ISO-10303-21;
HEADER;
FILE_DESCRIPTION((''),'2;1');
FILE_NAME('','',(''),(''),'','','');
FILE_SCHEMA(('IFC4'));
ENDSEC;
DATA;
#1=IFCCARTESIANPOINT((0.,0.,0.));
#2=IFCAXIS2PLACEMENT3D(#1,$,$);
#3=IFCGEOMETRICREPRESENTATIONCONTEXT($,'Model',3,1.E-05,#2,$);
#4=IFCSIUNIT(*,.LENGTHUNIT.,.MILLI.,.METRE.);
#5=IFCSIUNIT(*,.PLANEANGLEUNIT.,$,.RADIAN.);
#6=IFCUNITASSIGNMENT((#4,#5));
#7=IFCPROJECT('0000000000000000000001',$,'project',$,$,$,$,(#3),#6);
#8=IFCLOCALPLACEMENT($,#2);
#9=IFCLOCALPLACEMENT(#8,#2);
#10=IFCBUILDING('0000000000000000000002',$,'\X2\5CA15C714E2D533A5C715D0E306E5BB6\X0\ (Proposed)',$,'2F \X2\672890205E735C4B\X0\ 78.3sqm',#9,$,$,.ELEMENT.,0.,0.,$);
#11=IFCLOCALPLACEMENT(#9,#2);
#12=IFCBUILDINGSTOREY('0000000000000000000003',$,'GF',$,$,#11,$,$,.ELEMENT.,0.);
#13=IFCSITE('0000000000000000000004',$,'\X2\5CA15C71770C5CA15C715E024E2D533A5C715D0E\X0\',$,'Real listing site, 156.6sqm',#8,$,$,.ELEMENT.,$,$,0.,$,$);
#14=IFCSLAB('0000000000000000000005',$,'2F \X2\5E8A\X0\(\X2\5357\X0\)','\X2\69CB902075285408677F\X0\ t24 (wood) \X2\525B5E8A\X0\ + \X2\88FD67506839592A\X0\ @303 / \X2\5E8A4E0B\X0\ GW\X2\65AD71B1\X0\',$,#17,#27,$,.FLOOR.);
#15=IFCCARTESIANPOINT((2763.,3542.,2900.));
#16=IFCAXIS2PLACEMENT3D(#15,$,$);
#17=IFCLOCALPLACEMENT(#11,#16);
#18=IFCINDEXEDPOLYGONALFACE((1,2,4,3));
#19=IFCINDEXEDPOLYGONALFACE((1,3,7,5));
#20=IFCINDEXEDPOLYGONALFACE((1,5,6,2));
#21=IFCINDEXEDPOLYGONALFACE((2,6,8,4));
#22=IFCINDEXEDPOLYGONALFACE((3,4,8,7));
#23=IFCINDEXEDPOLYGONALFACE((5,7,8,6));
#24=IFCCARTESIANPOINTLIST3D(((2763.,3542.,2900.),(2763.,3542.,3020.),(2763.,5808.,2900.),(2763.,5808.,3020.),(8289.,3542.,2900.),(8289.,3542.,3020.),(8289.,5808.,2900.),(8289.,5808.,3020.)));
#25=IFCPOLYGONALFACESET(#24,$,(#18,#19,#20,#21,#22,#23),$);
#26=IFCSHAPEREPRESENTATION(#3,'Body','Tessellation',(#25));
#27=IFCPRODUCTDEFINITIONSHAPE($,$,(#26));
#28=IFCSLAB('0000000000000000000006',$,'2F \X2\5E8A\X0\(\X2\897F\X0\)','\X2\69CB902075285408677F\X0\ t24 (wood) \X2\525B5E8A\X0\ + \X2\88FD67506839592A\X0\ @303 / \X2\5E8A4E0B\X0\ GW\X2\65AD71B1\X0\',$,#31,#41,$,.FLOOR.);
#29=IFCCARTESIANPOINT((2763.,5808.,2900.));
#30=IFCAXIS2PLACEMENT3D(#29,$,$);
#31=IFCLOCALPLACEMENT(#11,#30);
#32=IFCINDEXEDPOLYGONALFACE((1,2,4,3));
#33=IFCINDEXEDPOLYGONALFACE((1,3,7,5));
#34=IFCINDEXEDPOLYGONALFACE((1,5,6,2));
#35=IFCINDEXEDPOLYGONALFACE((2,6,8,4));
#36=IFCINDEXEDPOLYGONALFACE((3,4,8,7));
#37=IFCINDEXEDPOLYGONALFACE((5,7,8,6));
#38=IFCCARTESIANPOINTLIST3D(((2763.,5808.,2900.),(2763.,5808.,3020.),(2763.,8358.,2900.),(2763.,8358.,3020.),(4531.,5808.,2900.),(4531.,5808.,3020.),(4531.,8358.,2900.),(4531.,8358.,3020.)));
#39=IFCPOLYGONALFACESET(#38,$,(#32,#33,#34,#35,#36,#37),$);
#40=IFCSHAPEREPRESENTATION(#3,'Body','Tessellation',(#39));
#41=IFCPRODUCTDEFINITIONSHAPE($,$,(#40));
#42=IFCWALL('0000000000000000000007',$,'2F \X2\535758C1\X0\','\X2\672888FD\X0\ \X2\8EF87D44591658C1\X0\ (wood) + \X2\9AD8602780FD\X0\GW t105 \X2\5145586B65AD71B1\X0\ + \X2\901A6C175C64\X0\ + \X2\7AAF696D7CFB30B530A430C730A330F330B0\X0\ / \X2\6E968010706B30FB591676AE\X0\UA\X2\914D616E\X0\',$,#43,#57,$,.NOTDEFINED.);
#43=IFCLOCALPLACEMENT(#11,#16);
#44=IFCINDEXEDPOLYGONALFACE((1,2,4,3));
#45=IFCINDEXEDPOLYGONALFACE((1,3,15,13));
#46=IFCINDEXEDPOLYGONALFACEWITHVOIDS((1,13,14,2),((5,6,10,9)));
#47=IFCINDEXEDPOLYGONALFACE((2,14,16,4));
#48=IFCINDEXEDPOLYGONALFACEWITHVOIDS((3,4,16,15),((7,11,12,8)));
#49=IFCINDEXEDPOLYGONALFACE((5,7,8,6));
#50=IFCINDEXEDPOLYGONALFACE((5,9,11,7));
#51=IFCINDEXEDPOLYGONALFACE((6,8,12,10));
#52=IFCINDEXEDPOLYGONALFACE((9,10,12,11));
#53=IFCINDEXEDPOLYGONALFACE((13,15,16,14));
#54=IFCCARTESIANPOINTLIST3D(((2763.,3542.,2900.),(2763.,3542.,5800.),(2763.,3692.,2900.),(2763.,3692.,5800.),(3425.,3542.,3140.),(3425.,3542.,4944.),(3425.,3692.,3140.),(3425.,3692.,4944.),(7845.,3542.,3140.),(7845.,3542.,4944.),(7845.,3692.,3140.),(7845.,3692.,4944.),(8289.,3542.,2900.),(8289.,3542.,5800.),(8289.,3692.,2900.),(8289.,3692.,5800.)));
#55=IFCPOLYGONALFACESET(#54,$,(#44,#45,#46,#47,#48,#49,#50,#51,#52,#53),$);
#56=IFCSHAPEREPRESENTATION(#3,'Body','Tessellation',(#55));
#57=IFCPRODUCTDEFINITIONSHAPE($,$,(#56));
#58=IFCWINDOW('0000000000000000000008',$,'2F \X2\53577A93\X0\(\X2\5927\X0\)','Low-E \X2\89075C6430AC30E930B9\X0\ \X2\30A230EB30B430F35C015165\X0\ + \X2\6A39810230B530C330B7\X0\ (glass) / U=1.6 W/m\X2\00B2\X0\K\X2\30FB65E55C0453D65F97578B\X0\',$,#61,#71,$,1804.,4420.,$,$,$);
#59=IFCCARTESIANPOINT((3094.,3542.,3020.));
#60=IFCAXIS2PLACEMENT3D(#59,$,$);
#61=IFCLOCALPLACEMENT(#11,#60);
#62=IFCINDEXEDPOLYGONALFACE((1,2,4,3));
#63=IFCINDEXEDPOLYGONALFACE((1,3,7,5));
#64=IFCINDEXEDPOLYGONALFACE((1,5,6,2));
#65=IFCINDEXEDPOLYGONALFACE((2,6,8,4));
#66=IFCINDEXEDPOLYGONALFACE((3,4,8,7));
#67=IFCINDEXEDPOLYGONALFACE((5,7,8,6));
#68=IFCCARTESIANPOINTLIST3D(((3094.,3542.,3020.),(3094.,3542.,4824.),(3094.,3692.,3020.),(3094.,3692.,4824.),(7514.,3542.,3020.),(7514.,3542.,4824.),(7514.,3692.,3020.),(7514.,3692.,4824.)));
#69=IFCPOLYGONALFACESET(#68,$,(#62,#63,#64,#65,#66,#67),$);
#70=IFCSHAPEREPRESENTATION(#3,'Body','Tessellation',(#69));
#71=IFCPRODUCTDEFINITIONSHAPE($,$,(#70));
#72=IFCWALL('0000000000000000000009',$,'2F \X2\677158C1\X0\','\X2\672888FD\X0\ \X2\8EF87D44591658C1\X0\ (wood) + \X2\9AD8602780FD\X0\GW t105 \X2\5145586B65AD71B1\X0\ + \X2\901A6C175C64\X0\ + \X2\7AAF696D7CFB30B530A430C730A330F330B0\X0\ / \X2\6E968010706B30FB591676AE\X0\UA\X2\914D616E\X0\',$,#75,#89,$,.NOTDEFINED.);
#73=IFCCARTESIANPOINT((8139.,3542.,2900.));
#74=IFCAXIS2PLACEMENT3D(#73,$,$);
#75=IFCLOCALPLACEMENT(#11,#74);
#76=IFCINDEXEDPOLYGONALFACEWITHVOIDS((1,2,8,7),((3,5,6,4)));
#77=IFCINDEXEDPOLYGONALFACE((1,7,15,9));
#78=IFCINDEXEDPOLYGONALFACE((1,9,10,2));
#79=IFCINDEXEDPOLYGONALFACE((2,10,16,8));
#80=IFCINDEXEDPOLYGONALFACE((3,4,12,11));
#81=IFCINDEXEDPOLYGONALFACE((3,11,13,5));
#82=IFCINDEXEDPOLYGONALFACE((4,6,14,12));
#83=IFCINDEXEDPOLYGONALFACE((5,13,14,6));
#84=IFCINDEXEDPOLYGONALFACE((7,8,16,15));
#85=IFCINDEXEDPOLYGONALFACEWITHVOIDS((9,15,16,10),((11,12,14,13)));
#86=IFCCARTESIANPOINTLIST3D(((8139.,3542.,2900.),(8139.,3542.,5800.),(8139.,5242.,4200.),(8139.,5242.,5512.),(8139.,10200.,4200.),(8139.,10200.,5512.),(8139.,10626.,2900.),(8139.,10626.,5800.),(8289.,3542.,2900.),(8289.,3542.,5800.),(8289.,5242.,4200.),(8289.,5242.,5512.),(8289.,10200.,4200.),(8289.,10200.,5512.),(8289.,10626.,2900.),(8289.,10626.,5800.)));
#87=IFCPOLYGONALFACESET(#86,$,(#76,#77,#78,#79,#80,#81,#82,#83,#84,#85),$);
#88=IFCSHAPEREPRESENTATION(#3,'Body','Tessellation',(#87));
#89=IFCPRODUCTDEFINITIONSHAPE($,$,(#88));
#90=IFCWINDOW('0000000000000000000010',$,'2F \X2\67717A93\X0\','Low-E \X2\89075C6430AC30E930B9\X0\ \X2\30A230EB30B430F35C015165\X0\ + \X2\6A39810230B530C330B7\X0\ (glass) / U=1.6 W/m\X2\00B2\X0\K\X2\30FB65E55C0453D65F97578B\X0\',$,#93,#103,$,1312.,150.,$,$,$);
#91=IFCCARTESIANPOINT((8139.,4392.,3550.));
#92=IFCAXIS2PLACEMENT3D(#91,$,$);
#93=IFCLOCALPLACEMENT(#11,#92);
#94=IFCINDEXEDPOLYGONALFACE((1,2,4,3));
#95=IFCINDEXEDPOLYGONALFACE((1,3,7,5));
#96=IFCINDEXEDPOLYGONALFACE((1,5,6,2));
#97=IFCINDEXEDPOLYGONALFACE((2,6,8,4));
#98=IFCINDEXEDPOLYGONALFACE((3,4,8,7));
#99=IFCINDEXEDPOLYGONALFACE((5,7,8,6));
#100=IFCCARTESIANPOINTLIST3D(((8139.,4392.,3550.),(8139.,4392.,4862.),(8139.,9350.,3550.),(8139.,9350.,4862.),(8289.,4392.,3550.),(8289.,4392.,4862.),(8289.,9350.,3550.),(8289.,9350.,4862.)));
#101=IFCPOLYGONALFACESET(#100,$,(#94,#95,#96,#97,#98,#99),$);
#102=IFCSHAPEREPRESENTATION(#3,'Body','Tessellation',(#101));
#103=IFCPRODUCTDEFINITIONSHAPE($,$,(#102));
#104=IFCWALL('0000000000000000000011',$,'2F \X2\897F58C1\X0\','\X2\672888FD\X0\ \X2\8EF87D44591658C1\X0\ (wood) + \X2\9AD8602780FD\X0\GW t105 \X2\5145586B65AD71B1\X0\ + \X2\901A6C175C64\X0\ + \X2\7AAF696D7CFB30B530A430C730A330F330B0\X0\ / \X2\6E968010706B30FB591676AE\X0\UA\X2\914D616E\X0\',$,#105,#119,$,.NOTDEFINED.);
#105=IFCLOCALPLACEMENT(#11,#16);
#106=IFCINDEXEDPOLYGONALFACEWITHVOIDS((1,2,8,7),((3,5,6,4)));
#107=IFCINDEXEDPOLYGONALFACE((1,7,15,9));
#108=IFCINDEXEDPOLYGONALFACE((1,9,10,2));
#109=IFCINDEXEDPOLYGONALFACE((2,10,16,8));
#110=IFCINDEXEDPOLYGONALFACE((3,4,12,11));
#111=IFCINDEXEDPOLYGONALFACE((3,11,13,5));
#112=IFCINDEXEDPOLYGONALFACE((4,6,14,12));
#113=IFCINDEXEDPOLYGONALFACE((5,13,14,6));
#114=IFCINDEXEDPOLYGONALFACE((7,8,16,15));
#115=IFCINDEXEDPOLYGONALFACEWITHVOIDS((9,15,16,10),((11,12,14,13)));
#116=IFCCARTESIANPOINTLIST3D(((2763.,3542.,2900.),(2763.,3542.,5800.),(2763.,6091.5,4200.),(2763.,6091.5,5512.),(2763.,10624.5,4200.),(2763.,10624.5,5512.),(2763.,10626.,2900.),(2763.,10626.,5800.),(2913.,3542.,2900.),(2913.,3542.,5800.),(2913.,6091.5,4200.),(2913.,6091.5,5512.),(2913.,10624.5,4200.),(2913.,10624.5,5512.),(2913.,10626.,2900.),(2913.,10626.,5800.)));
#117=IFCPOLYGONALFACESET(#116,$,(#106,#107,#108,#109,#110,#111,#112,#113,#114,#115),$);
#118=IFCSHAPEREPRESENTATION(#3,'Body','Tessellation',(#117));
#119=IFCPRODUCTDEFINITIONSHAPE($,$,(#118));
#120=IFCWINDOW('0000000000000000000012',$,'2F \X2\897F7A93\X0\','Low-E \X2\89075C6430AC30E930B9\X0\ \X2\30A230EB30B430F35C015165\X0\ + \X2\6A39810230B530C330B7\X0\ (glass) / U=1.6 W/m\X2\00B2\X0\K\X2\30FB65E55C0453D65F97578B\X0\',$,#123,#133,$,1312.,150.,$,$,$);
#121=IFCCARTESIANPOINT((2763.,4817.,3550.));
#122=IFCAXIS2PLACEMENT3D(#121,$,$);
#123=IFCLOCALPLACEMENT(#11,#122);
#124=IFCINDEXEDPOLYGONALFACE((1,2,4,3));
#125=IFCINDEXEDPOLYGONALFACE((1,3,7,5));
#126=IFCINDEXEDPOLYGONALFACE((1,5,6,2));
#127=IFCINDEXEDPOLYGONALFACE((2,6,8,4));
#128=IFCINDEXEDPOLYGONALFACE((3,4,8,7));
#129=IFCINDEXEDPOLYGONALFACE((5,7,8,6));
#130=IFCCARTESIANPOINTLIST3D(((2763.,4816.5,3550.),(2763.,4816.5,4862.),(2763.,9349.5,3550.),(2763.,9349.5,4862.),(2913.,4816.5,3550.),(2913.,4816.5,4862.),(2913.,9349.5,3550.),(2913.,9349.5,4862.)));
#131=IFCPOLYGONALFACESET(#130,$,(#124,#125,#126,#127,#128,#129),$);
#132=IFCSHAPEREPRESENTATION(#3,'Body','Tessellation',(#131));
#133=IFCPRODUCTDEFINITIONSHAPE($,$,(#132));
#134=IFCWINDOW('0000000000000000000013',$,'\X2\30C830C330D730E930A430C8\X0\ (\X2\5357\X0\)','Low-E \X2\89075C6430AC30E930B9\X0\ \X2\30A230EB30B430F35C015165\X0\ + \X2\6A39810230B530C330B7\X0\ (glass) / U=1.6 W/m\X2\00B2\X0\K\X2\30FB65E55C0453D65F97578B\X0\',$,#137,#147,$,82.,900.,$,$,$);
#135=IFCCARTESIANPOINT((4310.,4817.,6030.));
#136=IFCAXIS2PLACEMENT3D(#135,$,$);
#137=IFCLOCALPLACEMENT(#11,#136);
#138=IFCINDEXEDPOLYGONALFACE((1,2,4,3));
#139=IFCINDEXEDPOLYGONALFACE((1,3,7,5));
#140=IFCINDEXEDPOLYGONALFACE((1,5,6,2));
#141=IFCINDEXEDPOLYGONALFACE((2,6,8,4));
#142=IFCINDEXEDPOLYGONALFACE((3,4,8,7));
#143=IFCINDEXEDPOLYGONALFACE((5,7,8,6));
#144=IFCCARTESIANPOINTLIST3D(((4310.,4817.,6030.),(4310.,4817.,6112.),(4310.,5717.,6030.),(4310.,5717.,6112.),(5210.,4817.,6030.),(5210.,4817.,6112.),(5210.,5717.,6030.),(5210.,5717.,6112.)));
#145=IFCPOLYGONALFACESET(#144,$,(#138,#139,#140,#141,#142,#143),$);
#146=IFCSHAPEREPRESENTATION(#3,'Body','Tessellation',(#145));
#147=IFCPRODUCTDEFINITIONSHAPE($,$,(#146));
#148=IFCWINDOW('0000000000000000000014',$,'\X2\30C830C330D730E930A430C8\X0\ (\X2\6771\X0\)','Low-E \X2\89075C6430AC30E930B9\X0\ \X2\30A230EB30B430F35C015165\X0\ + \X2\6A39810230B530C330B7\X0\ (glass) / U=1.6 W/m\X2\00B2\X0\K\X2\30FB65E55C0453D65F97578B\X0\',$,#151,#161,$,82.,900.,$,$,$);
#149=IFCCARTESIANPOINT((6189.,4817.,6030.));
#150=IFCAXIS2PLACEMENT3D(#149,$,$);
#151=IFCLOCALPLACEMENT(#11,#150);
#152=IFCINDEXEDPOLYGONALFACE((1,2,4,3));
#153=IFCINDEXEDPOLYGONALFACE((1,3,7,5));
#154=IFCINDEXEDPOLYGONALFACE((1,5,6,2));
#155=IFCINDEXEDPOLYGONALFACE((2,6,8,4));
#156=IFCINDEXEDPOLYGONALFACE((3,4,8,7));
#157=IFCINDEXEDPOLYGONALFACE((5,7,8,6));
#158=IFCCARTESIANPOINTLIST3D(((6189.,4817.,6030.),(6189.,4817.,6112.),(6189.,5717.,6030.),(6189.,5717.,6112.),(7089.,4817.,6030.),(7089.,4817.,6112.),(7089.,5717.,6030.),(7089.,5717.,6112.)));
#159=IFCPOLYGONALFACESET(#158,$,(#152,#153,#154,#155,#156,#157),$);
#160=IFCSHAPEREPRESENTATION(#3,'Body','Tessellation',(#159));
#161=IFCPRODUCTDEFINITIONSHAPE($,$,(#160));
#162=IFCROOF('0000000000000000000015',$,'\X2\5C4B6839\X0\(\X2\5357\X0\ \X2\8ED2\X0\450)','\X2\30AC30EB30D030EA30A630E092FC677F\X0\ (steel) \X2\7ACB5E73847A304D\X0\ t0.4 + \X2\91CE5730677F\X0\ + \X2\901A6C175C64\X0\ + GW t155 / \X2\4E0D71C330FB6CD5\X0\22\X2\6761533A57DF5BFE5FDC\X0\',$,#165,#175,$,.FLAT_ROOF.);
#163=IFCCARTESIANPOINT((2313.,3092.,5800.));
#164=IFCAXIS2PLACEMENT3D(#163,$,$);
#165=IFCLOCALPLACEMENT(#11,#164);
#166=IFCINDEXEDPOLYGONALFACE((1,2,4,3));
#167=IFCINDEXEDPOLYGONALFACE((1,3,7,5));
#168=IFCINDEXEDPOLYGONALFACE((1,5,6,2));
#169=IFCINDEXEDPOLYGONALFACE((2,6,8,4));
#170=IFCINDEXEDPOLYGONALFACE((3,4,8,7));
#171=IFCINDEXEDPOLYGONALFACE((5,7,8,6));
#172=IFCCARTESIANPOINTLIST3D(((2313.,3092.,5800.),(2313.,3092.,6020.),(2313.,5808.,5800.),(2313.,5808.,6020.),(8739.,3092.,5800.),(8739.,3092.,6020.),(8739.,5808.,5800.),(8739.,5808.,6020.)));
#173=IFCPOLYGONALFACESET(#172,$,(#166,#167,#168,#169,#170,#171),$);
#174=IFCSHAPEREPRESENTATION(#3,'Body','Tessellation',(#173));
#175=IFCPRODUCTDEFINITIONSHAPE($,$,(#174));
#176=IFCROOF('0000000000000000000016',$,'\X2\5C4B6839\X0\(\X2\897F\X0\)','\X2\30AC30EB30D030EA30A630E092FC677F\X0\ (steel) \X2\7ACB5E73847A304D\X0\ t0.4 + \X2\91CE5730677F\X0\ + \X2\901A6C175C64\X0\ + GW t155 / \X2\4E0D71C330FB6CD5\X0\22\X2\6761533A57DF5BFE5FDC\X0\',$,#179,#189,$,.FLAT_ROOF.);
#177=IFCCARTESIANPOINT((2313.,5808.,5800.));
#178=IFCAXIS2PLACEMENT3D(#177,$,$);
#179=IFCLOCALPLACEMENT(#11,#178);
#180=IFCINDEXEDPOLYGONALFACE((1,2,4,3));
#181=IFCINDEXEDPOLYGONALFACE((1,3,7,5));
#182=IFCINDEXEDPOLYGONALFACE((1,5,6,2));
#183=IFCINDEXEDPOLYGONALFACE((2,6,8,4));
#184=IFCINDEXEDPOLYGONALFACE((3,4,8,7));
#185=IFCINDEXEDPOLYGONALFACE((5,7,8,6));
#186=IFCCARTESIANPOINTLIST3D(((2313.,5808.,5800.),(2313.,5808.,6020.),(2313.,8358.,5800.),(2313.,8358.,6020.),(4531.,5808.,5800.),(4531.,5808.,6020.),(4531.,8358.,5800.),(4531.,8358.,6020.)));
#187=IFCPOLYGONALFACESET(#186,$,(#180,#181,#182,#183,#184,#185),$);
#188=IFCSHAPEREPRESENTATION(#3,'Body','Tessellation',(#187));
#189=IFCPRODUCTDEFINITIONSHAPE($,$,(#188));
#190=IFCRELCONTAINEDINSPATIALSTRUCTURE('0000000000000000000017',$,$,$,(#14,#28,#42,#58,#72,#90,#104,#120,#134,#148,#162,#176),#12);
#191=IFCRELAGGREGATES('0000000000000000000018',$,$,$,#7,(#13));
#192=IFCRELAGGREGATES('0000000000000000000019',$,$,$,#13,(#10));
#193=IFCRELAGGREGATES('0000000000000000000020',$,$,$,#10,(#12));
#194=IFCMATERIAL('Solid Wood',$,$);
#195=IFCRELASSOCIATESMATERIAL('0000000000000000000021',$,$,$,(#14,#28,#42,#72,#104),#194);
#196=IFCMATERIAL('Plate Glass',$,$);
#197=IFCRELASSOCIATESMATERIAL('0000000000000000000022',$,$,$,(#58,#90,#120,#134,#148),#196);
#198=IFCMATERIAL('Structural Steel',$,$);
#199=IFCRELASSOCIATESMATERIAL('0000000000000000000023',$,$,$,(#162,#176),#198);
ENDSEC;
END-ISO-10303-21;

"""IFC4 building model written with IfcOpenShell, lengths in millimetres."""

from ifc_helpers import new_model, si_unit, frame, frame_2d, origin, place, context, project, spatial, rectangle, extrude, material, element, fill, save


model = new_model("IFC4")

# Units and contexts
model_context = context("Model", 3, precision=1e-05, world=origin())
ifc_project = project(units=[si_unit("LENGTHUNIT", "METRE", prefix="MILLI"), si_unit("PLANEANGLEUNIT", "RADIAN")], contexts=[model_context])

# Site, building, storey
site_placement = place(None, origin())
site = spatial("IfcSite", under=ifc_project, at=site_placement, Name="岡山県岡山市中区山崎", ObjectType="Real listing site, 156.6sqm", CompositionType="ELEMENT", RefElevation=0.0)
building_placement = place(site_placement, origin())
building = spatial("IfcBuilding", under=site, at=building_placement, Name="岡山中区山崎の家 (Proposed)", ObjectType="2F 木造平屋 78.3sqm", CompositionType="ELEMENT", ElevationOfRefHeight=0.0, ElevationOfTerrain=0.0)
storey_placement = place(building_placement, origin())
storey = spatial("IfcBuildingStorey", under=building, at=storey_placement, Name="GF", CompositionType="ELEMENT", Elevation=0.0)

# Slabs
ifc_material_1 = material(Name="Solid Wood")
slab_1_placement = place(storey_placement, frame((2763.0, 3542.0, 2900.0)))
element("IfcSlab", 1, at=slab_1_placement, inside=storey, material=ifc_material_1, Name="2F 床(南)", Description="構造用合板 t24 (wood) 剛床 + 製材根太 @303 / 床下 GW断熱", PredefinedType="FLOOR", context=model_context, shape_type="SweptSolid", body=[
    extrude(rectangle(XDim=5526.0, YDim=2266.0, at=frame_2d((2763.0, 1133.0))), frame((2763.0, 3542.0, 2900.0)), (0.0, 0.0, 1.0), 120.0),
])
slab_2_placement = place(storey_placement, frame((2763.0, 5808.0, 2900.0)))
element("IfcSlab", 2, at=slab_2_placement, inside=storey, material=ifc_material_1, Name="2F 床(西)", Description="構造用合板 t24 (wood) 剛床 + 製材根太 @303 / 床下 GW断熱", PredefinedType="FLOOR", context=model_context, shape_type="SweptSolid", body=[
    extrude(rectangle(XDim=1768.0, YDim=2550.0, at=frame_2d((884.0, 1275.0))), frame((2763.0, 5808.0, 2900.0)), (0.0, 0.0, 1.0), 120.0),
])

# Walls, openings, windows
wall_1_placement = place(storey_placement, frame((2763.0, 3542.0, 2900.0)))
wall_1 = element("IfcWall", 3, at=wall_1_placement, inside=storey, material=ifc_material_1, Name="2F 南壁", Description="木製 軸組外壁 (wood) + 高性能GW t105 充填断熱 + 通気層 + 窯業系サイディング / 準耐火・外皮UA配慮", PredefinedType="NOTDEFINED", context=model_context, shape_type="SweptSolid", body=[
    extrude(rectangle(XDim=5526.0, YDim=150.0, at=frame_2d((2763.0, 75.0))), frame((2763.0, 3542.0, 2900.0)), (0.0, 0.0, 1.0), 2900.0),
])
opening_1_placement = place(storey_placement, frame((3094.0, 3542.0, 3020.0)))
opening_1 = element("IfcOpeningElement", 4, at=opening_1_placement, cuts=wall_1, PredefinedType="NOTDEFINED", context=model_context, shape_type="SweptSolid", body=[
    extrude(rectangle(XDim=4420.0, YDim=150.0, at=frame_2d((2210.0, 75.0))), frame((3094.0, 3542.0, 3020.0)), (0.0, 0.0, 1.0), 1804.0),
])
ifc_material_2 = material(Name="Plate Glass")
window_1_placement = place(storey_placement, frame((3094.0, 3542.0, 3020.0)))
window_1 = element("IfcWindow", 5, at=window_1_placement, inside=storey, material=ifc_material_2, Name="2F 南窓(大)", Description="Low-E 複層ガラス アルゴン封入 + 樹脂サッシ (glass) / U=1.6 W/m²K・日射取得型", OverallHeight=1804.0, OverallWidth=4420.0, context=model_context, shape_type="SweptSolid", body=[
    extrude(rectangle(XDim=4420.0, YDim=150.0, at=frame_2d((2210.0, 75.0))), frame((3094.0, 3542.0, 3020.0)), (0.0, 0.0, 1.0), 1804.0),
])
fill(opening_1, window_1)
wall_2_placement = place(storey_placement, frame((8139.0, 3542.0, 2900.0)))
wall_2 = element("IfcWall", 6, at=wall_2_placement, inside=storey, material=ifc_material_1, Name="2F 東壁", Description="木製 軸組外壁 (wood) + 高性能GW t105 充填断熱 + 通気層 + 窯業系サイディング / 準耐火・外皮UA配慮", PredefinedType="NOTDEFINED", context=model_context, shape_type="SweptSolid", body=[
    extrude(rectangle(XDim=150.0, YDim=7084.0, at=frame_2d((75.0, 3542.0))), frame((8139.0, 3542.0, 2900.0)), (0.0, 0.0, 1.0), 2900.0),
])
opening_2_placement = place(storey_placement, frame((8139.0, 4392.0, 3550.0)))
opening_2 = element("IfcOpeningElement", 7, at=opening_2_placement, cuts=wall_2, PredefinedType="NOTDEFINED", context=model_context, shape_type="SweptSolid", body=[
    extrude(rectangle(XDim=150.0, YDim=4958.0, at=frame_2d((75.0, 2479.0))), frame((8139.0, 4392.0, 3550.0)), (0.0, 0.0, 1.0), 1312.0),
])
window_2_placement = place(storey_placement, frame((8139.0, 4392.0, 3550.0)))
window_2 = element("IfcWindow", 8, at=window_2_placement, inside=storey, material=ifc_material_2, Name="2F 東窓", Description="Low-E 複層ガラス アルゴン封入 + 樹脂サッシ (glass) / U=1.6 W/m²K・日射取得型", OverallHeight=1312.0, OverallWidth=150.0, context=model_context, shape_type="SweptSolid", body=[
    extrude(rectangle(XDim=150.0, YDim=4958.0, at=frame_2d((75.0, 2479.0))), frame((8139.0, 4392.0, 3550.0)), (0.0, 0.0, 1.0), 1312.0),
])
fill(opening_2, window_2)
wall_3_placement = place(storey_placement, frame((2763.0, 3542.0, 2900.0)))
wall_3 = element("IfcWall", 9, at=wall_3_placement, inside=storey, material=ifc_material_1, Name="2F 西壁", Description="木製 軸組外壁 (wood) + 高性能GW t105 充填断熱 + 通気層 + 窯業系サイディング / 準耐火・外皮UA配慮", PredefinedType="NOTDEFINED", context=model_context, shape_type="SweptSolid", body=[
    extrude(rectangle(XDim=150.0, YDim=7084.0, at=frame_2d((75.0, 3542.0))), frame((2763.0, 3542.0, 2900.0)), (0.0, 0.0, 1.0), 2900.0),
])
opening_3_placement = place(storey_placement, frame((2763.0, 4817.0, 3550.0)))
opening_3 = element("IfcOpeningElement", 10, at=opening_3_placement, cuts=wall_3, PredefinedType="NOTDEFINED", context=model_context, shape_type="SweptSolid", body=[
    extrude(rectangle(XDim=150.0, YDim=4533.0, at=frame_2d((75.0, 2266.0))), frame((2763.0, 4817.0, 3550.0)), (0.0, 0.0, 1.0), 1312.0),
])
window_3_placement = place(storey_placement, frame((2763.0, 4817.0, 3550.0)))
window_3 = element("IfcWindow", 11, at=window_3_placement, inside=storey, material=ifc_material_2, Name="2F 西窓", Description="Low-E 複層ガラス アルゴン封入 + 樹脂サッシ (glass) / U=1.6 W/m²K・日射取得型", OverallHeight=1312.0, OverallWidth=150.0, context=model_context, shape_type="SweptSolid", body=[
    extrude(rectangle(XDim=150.0, YDim=4533.0, at=frame_2d((75.0, 2266.0))), frame((2763.0, 4817.0, 3550.0)), (0.0, 0.0, 1.0), 1312.0),
])
fill(opening_3, window_3)

# Windows
window_4_placement = place(storey_placement, frame((4310.0, 4817.0, 6030.0)))
element("IfcWindow", 12, at=window_4_placement, inside=storey, material=ifc_material_2, Name="トップライト (南)", Description="Low-E 複層ガラス アルゴン封入 + 樹脂サッシ (glass) / U=1.6 W/m²K・日射取得型", OverallHeight=82.0, OverallWidth=900.0, context=model_context, shape_type="SweptSolid", body=[
    extrude(rectangle(XDim=900.0, YDim=900.0, at=frame_2d((450.0, 450.0))), frame((4310.0, 4817.0, 6030.0)), (0.0, 0.0, 1.0), 82.0),
])
window_5_placement = place(storey_placement, frame((6189.0, 4817.0, 6030.0)))
element("IfcWindow", 13, at=window_5_placement, inside=storey, material=ifc_material_2, Name="トップライト (東)", Description="Low-E 複層ガラス アルゴン封入 + 樹脂サッシ (glass) / U=1.6 W/m²K・日射取得型", OverallHeight=82.0, OverallWidth=900.0, context=model_context, shape_type="SweptSolid", body=[
    extrude(rectangle(XDim=900.0, YDim=900.0, at=frame_2d((450.0, 450.0))), frame((6189.0, 4817.0, 6030.0)), (0.0, 0.0, 1.0), 82.0),
])

# Roofs
ifc_material_3 = material(Name="Structural Steel")
roof_1_placement = place(storey_placement, frame((2313.0, 3092.0, 5800.0)))
element("IfcRoof", 14, at=roof_1_placement, inside=storey, material=ifc_material_3, Name="屋根(南 軒450)", Description="ガルバリウム鋼板 (steel) 立平葺き t0.4 + 野地板 + 通気層 + GW t155 / 不燃・法22条区域対応", PredefinedType="FLAT_ROOF", context=model_context, shape_type="SweptSolid", body=[
    extrude(rectangle(XDim=6426.0, YDim=2716.0, at=frame_2d((3213.0, 1358.0))), frame((2313.0, 3092.0, 5800.0)), (0.0, 0.0, 1.0), 220.0),
])
roof_2_placement = place(storey_placement, frame((2313.0, 5808.0, 5800.0)))
element("IfcRoof", 15, at=roof_2_placement, inside=storey, material=ifc_material_3, Name="屋根(西)", Description="ガルバリウム鋼板 (steel) 立平葺き t0.4 + 野地板 + 通気層 + GW t155 / 不燃・法22条区域対応", PredefinedType="FLAT_ROOF", context=model_context, shape_type="SweptSolid", body=[
    extrude(rectangle(XDim=2218.0, YDim=2550.0, at=frame_2d((1109.0, 1275.0))), frame((2313.0, 5808.0, 5800.0)), (0.0, 0.0, 1.0), 220.0),
])

save(model, "model.ifc")
